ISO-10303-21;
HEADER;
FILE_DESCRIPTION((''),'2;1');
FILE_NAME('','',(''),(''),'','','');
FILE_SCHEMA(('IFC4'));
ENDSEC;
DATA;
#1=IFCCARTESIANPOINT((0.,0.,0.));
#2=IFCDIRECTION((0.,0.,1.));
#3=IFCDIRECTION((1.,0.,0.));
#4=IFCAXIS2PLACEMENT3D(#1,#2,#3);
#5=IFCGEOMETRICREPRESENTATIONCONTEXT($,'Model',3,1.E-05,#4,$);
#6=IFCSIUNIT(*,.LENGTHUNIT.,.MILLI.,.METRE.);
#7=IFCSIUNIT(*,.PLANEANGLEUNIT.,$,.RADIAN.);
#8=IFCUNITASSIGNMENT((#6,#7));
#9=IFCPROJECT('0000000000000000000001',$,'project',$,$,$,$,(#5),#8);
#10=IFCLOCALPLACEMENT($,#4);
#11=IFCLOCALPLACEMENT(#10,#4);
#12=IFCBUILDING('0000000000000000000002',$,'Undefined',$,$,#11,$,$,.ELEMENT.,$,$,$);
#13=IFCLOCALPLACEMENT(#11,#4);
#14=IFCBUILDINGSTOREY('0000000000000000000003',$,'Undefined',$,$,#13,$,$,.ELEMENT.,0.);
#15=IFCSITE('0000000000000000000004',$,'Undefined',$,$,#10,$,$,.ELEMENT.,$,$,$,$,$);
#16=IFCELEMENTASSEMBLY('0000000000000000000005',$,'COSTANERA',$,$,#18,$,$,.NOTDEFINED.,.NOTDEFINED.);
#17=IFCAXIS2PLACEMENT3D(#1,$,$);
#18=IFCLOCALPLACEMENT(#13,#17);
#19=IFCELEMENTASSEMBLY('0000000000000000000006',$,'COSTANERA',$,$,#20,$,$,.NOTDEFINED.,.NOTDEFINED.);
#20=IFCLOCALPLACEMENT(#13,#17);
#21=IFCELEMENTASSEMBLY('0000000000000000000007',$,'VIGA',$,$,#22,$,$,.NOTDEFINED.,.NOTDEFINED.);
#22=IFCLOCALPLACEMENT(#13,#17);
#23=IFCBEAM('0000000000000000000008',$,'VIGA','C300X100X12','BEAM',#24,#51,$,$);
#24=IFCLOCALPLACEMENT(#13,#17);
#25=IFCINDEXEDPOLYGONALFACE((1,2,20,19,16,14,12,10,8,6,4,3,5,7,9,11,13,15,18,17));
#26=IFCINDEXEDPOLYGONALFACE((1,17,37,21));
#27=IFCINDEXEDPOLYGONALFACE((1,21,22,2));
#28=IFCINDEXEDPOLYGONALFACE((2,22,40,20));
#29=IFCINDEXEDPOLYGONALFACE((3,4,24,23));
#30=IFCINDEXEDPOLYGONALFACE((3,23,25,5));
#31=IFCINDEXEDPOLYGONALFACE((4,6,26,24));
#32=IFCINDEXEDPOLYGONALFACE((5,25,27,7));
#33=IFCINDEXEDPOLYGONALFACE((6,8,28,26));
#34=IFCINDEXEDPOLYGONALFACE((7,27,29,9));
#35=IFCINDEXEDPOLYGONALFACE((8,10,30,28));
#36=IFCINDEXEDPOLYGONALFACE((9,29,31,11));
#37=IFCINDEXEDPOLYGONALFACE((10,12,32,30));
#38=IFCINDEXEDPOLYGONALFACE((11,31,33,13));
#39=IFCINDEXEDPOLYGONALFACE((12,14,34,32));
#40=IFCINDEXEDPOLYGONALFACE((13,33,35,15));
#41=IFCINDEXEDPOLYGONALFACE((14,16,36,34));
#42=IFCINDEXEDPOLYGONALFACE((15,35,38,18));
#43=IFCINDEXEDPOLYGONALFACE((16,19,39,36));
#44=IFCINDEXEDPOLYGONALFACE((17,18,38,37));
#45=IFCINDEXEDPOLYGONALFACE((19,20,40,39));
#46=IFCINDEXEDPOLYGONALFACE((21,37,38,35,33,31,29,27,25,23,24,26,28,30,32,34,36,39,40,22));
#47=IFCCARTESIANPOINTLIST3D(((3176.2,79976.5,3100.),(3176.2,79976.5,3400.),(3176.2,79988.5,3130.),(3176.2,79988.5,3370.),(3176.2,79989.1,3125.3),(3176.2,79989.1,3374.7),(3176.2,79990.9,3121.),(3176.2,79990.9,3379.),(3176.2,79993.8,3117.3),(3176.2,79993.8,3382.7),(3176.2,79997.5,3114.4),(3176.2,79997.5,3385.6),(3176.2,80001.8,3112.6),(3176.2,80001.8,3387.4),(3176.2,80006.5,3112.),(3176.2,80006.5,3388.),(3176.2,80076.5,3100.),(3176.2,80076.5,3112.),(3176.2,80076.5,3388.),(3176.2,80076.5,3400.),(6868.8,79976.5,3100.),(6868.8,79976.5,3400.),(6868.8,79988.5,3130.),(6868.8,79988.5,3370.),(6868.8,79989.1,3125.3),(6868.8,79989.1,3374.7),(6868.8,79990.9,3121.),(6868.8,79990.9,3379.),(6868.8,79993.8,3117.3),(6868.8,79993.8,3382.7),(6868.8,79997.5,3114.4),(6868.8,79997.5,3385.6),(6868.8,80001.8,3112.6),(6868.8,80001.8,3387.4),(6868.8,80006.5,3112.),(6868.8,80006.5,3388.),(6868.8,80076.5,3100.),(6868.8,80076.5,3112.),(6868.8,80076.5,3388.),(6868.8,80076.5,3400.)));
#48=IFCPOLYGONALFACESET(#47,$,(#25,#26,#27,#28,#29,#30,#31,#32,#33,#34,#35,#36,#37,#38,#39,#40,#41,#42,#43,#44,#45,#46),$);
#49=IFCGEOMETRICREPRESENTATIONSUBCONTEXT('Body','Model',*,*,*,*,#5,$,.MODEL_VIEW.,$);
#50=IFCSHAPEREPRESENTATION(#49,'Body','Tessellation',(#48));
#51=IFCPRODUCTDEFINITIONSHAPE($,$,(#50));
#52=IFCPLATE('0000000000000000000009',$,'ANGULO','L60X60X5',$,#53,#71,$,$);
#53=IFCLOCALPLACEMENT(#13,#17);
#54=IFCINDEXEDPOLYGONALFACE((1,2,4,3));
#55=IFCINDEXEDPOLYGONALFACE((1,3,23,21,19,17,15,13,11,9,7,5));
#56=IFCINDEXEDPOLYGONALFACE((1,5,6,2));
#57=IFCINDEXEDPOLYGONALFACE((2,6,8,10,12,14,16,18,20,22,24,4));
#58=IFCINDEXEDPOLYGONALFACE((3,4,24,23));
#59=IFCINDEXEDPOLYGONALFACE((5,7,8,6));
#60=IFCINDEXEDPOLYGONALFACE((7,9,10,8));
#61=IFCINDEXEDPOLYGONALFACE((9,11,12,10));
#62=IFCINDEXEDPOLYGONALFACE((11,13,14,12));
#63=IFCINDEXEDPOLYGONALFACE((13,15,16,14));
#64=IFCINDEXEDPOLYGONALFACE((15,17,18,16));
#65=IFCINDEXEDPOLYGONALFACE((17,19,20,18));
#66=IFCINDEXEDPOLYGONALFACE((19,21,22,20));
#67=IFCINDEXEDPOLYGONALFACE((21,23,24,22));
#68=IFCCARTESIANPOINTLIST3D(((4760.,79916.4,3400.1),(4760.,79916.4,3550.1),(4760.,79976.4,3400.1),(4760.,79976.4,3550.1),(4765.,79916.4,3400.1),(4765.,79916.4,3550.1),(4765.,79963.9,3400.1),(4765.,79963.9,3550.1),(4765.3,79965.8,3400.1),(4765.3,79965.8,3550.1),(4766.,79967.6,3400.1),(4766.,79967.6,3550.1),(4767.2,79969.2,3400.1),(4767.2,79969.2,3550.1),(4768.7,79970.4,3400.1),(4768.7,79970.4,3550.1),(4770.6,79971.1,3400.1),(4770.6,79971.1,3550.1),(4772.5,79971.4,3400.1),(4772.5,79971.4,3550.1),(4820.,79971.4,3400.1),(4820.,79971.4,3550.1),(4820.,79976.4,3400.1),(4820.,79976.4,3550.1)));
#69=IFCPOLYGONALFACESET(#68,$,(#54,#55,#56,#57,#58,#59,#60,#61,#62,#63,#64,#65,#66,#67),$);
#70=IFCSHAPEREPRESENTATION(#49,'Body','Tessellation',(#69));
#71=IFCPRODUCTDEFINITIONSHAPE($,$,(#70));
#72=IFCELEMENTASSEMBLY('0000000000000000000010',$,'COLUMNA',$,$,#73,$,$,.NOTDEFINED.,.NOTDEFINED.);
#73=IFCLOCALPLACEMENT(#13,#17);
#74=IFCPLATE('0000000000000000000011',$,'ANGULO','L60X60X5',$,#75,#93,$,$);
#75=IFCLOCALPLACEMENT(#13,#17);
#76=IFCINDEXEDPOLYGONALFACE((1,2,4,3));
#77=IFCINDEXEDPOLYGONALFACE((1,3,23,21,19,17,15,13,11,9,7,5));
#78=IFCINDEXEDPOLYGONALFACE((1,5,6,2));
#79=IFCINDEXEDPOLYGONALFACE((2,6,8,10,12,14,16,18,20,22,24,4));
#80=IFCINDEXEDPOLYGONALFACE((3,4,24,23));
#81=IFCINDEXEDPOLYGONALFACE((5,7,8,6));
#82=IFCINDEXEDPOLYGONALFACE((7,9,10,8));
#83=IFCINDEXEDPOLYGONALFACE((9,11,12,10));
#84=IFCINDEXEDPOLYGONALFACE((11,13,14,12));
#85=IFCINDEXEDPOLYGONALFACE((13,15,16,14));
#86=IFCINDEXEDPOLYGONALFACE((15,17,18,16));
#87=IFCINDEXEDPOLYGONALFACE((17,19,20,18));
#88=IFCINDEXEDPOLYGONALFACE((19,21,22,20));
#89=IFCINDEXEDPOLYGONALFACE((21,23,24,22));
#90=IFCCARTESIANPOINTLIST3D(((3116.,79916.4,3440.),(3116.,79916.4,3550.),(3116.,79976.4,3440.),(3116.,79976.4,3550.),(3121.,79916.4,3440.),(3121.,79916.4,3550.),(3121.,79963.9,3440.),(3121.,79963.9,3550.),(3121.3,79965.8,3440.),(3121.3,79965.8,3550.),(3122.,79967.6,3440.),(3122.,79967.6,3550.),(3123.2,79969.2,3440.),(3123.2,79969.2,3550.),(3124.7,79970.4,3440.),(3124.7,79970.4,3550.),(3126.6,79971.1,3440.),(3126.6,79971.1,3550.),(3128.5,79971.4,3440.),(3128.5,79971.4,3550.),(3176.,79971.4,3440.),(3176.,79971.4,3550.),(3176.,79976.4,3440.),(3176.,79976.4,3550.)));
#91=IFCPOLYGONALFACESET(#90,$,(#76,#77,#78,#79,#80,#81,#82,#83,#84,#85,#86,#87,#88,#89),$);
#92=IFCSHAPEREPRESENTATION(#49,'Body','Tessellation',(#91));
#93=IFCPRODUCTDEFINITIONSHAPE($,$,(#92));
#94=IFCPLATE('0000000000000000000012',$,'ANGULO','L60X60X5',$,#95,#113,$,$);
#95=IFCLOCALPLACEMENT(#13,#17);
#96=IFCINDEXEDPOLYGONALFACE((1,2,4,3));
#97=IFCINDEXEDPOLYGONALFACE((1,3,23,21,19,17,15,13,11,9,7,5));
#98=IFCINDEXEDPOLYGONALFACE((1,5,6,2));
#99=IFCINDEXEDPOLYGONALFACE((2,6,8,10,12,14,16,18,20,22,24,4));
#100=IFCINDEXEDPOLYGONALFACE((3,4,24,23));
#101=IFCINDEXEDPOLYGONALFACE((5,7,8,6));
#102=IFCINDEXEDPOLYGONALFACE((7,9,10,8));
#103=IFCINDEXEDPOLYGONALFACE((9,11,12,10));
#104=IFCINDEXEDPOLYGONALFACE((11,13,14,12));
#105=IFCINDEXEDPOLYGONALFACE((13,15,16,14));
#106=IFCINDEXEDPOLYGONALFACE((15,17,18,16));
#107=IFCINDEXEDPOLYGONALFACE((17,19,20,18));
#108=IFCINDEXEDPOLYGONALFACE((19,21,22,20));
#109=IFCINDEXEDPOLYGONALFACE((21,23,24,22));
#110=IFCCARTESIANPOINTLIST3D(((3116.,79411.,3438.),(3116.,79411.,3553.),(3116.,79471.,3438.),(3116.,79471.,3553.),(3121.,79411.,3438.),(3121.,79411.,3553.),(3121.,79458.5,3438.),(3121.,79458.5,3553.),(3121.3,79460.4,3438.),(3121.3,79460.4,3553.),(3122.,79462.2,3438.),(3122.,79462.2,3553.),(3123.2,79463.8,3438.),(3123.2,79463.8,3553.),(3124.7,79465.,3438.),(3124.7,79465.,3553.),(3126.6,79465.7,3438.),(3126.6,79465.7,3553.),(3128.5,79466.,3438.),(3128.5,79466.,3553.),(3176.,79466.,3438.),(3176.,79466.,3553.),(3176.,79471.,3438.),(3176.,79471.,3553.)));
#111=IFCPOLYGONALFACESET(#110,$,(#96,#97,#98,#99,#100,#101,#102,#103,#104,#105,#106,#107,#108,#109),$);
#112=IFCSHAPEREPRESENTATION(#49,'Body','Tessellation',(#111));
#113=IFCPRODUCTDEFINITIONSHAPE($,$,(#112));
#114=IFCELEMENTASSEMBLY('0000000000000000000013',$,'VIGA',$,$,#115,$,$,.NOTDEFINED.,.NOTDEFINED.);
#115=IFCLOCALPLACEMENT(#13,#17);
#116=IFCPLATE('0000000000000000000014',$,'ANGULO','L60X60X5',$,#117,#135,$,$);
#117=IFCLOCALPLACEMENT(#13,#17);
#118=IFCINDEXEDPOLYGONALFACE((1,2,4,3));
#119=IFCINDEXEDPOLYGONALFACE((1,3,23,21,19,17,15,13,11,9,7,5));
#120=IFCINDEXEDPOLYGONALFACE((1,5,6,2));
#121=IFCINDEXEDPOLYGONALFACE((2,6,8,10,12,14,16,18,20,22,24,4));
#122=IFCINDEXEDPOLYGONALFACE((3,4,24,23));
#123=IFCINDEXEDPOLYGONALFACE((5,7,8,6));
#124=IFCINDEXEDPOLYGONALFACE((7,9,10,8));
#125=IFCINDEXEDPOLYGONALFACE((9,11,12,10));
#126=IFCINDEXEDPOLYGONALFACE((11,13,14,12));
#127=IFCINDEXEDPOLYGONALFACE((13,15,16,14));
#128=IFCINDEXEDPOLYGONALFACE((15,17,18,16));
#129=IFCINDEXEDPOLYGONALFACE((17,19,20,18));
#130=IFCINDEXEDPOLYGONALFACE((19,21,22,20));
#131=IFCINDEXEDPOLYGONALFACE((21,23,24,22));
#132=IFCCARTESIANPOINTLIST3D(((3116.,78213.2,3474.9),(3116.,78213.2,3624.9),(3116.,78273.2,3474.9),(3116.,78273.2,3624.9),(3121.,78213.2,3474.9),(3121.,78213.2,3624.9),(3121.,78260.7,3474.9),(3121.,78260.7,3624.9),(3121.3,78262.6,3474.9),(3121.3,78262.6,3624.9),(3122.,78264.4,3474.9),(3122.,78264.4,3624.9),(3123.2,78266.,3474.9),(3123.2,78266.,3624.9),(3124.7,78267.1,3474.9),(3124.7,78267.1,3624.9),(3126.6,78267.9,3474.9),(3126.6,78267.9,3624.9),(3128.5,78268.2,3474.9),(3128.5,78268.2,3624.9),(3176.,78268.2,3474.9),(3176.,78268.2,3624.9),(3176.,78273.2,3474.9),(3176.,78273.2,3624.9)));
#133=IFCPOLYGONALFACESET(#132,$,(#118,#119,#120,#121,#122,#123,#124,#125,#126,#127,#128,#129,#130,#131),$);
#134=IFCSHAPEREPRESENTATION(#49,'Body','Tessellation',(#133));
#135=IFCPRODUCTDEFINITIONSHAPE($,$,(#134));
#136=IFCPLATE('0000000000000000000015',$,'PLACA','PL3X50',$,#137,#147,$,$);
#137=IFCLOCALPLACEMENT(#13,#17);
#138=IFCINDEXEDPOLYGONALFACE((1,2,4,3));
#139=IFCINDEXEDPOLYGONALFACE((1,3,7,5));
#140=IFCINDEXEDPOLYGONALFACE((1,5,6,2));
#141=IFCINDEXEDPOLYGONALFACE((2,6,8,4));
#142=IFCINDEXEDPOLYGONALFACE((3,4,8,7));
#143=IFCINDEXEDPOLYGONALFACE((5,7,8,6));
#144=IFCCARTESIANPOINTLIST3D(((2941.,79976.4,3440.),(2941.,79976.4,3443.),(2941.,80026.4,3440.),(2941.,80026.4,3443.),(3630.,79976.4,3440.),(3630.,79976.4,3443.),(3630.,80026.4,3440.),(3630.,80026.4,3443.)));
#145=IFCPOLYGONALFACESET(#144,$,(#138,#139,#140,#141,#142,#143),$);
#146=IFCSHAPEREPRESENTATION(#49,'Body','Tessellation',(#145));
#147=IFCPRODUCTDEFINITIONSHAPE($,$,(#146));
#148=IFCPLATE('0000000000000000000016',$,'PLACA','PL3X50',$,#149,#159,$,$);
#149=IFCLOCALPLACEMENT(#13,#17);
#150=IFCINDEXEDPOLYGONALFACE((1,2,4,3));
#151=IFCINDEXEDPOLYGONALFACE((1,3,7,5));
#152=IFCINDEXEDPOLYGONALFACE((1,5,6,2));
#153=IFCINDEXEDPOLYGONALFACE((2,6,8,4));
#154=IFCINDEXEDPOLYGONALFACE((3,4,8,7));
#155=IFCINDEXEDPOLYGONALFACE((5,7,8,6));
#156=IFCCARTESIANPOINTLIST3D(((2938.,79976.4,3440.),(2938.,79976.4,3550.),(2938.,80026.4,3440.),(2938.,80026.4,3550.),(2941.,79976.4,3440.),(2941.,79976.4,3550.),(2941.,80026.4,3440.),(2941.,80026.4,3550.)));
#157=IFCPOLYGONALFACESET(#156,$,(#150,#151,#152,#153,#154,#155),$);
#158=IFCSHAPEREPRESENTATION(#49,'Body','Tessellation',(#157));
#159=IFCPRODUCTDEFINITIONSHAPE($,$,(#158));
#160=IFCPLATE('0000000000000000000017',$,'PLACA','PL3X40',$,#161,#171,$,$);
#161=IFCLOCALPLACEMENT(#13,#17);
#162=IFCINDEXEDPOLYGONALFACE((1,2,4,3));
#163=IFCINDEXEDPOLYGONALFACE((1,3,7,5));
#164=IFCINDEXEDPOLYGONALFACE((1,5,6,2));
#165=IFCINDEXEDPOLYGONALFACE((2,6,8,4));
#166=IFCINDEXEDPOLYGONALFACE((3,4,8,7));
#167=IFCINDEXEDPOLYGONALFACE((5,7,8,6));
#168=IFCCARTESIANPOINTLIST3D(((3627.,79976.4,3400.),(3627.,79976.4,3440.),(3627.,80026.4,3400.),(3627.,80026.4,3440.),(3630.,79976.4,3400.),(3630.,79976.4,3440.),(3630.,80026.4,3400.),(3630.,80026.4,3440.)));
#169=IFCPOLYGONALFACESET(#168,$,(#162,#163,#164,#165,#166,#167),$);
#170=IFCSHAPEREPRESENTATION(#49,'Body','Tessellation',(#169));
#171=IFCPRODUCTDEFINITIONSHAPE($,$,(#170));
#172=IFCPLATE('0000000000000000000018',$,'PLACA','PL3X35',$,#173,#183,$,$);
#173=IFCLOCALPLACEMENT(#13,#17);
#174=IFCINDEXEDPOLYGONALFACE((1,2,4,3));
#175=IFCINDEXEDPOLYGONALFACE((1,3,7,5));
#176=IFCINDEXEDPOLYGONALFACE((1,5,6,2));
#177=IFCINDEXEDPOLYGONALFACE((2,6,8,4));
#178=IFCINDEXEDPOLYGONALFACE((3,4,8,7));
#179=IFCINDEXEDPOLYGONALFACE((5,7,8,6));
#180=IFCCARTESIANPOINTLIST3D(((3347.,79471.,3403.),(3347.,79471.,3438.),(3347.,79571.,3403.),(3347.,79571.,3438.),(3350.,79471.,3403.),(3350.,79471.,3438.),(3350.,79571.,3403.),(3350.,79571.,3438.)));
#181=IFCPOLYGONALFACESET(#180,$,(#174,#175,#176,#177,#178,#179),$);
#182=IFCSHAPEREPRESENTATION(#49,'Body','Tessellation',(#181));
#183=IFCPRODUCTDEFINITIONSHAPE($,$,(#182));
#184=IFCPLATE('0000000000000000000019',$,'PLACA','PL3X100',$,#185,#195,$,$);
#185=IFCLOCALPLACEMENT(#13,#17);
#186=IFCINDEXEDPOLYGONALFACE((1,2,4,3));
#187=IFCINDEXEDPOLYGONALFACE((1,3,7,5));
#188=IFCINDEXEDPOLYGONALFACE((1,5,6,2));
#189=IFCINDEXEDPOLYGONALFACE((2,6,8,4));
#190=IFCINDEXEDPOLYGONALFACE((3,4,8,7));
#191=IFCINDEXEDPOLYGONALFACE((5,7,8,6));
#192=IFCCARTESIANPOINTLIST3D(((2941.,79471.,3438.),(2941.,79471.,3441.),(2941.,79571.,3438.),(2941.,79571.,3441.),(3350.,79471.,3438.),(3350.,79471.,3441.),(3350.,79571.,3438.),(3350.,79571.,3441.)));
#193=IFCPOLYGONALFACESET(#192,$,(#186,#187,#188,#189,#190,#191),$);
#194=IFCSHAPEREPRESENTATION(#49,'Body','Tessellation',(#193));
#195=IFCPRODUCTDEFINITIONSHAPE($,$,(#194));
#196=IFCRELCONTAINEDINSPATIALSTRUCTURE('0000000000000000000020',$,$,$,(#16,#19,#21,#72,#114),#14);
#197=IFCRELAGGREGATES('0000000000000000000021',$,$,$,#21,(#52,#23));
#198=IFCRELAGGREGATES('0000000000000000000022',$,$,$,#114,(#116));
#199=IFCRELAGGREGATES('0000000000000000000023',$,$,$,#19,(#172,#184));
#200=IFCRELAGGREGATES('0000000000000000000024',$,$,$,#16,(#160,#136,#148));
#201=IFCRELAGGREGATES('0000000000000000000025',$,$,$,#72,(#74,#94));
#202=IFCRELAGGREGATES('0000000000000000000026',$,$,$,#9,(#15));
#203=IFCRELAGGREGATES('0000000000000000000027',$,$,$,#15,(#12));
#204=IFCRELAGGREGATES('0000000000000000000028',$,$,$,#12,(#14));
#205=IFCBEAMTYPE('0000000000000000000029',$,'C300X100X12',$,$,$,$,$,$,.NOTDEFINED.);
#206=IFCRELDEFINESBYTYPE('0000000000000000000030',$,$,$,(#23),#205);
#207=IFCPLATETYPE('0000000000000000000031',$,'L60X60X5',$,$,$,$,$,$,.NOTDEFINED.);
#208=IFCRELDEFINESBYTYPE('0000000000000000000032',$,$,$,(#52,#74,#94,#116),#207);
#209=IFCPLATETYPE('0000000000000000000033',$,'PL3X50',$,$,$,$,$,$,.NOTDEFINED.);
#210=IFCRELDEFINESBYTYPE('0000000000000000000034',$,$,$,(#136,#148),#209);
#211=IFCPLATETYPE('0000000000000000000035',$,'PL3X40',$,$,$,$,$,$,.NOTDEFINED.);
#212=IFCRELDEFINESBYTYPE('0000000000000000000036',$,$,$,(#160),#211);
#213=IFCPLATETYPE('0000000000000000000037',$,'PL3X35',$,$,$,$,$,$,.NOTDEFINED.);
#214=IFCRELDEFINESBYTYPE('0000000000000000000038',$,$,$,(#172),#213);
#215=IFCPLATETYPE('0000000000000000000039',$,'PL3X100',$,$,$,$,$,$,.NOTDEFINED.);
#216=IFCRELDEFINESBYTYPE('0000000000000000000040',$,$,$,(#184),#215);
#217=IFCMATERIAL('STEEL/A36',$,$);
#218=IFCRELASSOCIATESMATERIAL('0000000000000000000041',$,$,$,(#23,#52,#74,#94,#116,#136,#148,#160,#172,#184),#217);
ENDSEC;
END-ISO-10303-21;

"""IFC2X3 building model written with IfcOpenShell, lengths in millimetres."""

from ifc_helpers import new_model, si_unit, frame, origin_with_axes, origin_2d_with_axis, place, context, subcontext, project, spatial, polyline, l_section, u_section, outline, extrude, material, type_object, element, aggregate, save


model = new_model("IFC2X3")

# Units and contexts
model_context = context("Model", 3, precision=1e-05, world=origin_with_axes())
body_context = subcontext(model_context, "Body", "Model", "MODEL_VIEW")
ifc_project = project(units=[si_unit("LENGTHUNIT", "METRE", prefix="MILLI"), si_unit("PLANEANGLEUNIT", "RADIAN")], contexts=[model_context])

# Site, building, storey
site_placement = place(None, origin_with_axes())
site = spatial("IfcSite", under=ifc_project, at=site_placement, Name="Undefined", CompositionType="ELEMENT")
building_placement = place(site_placement, origin_with_axes())
building = spatial("IfcBuilding", under=site, at=building_placement, Name="Undefined", CompositionType="ELEMENT")
storey_placement = place(building_placement, origin_with_axes())
storey = spatial("IfcBuildingStorey", under=building, at=storey_placement, Name="Undefined", CompositionType="ELEMENT", Elevation=0.0)

# Element assemblies
assembly_1_placement = place(storey_placement, origin_with_axes())
assembly_1 = element("IfcElementAssembly", 1, at=assembly_1_placement, inside=storey, Name="COSTANERA", AssemblyPlace="NOTDEFINED", PredefinedType="NOTDEFINED")
ifc_material_1 = material(Name="STEEL/A36")
assembly_2_placement = place(storey_placement, origin_with_axes())
assembly_2 = element("IfcElementAssembly", 2, at=assembly_2_placement, inside=storey, Name="COSTANERA", AssemblyPlace="NOTDEFINED", PredefinedType="NOTDEFINED")

# Element assembly, beam, plate
assembly_3_placement = place(storey_placement, origin_with_axes())
assembly_3 = element("IfcElementAssembly", 3, at=assembly_3_placement, inside=storey, Name="VIGA", AssemblyPlace="NOTDEFINED", PredefinedType="NOTDEFINED")
beam_type_1 = type_object("IfcBeamType", Name="C300X100X12", PredefinedType="NOTDEFINED")
beam_1_placement = place(assembly_3_placement, frame((3176.2, 80026.5, 3250.0), z_axis=(0.0, 0.0, -1.0), x_axis=(1.0, 0.0, 0.0)))
beam_1 = element("IfcBeam", 4, at=beam_1_placement, type_object=beam_type_1, material=ifc_material_1, Name="VIGA", Description="C300X100X12", ObjectType="BEAM", context=body_context, shape_type="SweptSolid", body=[
    extrude(u_section(Depth=300.0, FlangeWidth=100.0, WebThickness=12.0, FlangeThickness=12.0, FilletRadius=18.0, at=origin_2d_with_axis()), frame((3692.6, 0.0, 0.0), z_axis=(-1.0, 0.0, 0.0), x_axis=(0.0, -1.0, 0.0)), (0.0, 0.0, 1.0), 3692.6),
])
plate_type_1 = type_object("IfcPlateType", Name="L60X60X5", PredefinedType="NOTDEFINED")
plate_1_placement = place(assembly_3_placement, frame((4790.0, 79946.4, 3400.1), z_axis=(0.0, -1.0, 0.0), x_axis=(0.0, 0.0, 1.0)))
plate_1 = element("IfcPlate", 5, at=plate_1_placement, type_object=plate_type_1, material=ifc_material_1, Name="ANGULO", Description="L60X60X5", context=body_context, shape_type="SweptSolid", body=[
    extrude(l_section(Depth=60.0, Width=60.0, Thickness=5.0, FilletRadius=7.5, at=origin_2d_with_axis()), frame((150.0, 0.0, 0.0), z_axis=(-1.0, 0.0, 0.0), x_axis=(0.0, -1.0, 0.0)), (0.0, 0.0, 1.0), 150.0),
])
aggregate(assembly_3, [plate_1, beam_1])

# Element assembly, plates
assembly_4_placement = place(storey_placement, origin_with_axes())
assembly_4 = element("IfcElementAssembly", 6, at=assembly_4_placement, inside=storey, Name="COLUMNA", AssemblyPlace="NOTDEFINED", PredefinedType="NOTDEFINED")
plate_2_placement = place(assembly_4_placement, frame((3146.0, 79946.4, 3440.0), z_axis=(0.0, -1.0, 0.0), x_axis=(0.0, 0.0, 1.0)))
plate_2 = element("IfcPlate", 7, at=plate_2_placement, type_object=plate_type_1, material=ifc_material_1, Name="ANGULO", Description="L60X60X5", context=body_context, shape_type="SweptSolid", body=[
    extrude(l_section(Depth=60.0, Width=60.0, Thickness=5.0, FilletRadius=7.5, at=origin_2d_with_axis()), frame((110.0, 0.0, 0.0), z_axis=(-1.0, 0.0, 0.0), x_axis=(0.0, -1.0, 0.0)), (0.0, 0.0, 1.0), 110.0),
])
plate_3_placement = place(assembly_4_placement, frame((3146.0, 79441.0, 3438.0), z_axis=(0.0, -1.0, 0.0), x_axis=(0.0, 0.0, 1.0)))
plate_3 = element("IfcPlate", 8, at=plate_3_placement, type_object=plate_type_1, material=ifc_material_1, Name="ANGULO", Description="L60X60X5", context=body_context, shape_type="SweptSolid", body=[
    extrude(l_section(Depth=60.0, Width=60.0, Thickness=5.0, FilletRadius=7.5, at=origin_2d_with_axis()), frame((115.0, 0.0, 0.0), z_axis=(-1.0, 0.0, 0.0), x_axis=(0.0, -1.0, 0.0)), (0.0, 0.0, 1.0), 115.0),
])

# Element assembly, plate
assembly_5_placement = place(storey_placement, origin_with_axes())
assembly_5 = element("IfcElementAssembly", 9, at=assembly_5_placement, inside=storey, Name="VIGA", AssemblyPlace="NOTDEFINED", PredefinedType="NOTDEFINED")
plate_4_placement = place(assembly_5_placement, frame((3146.0, 78243.2, 3474.9), z_axis=(0.0, -1.0, 0.0), x_axis=(0.0, 0.0, 1.0)))
plate_4 = element("IfcPlate", 10, at=plate_4_placement, type_object=plate_type_1, material=ifc_material_1, Name="ANGULO", Description="L60X60X5", context=body_context, shape_type="SweptSolid", body=[
    extrude(l_section(Depth=60.0, Width=60.0, Thickness=5.0, FilletRadius=7.5, at=origin_2d_with_axis()), frame((150.0, 0.0, 0.0), z_axis=(-1.0, 0.0, 0.0), x_axis=(0.0, -1.0, 0.0)), (0.0, 0.0, 1.0), 150.0),
])
aggregate(assembly_5, [plate_4])

# Plates
plate_type_2 = type_object("IfcPlateType", Name="PL3X50", PredefinedType="NOTDEFINED")
plate_5_placement = place(assembly_1_placement, frame((2941.0, 79976.4, 3441.5), z_axis=(0.0, 0.0, 1.0), x_axis=(1.0, 0.0, 0.0)))
plate_5 = element("IfcPlate", 11, at=plate_5_placement, type_object=plate_type_2, material=ifc_material_1, Name="PLACA", Description="PL3X50", context=body_context, shape_type="SweptSolid", body=[
    extrude(outline(polyline([(0.0, 0.0), (689.0, 0.0), (689.0, 50.0), (0.0, 50.0), (0.0, 0.0)])), frame((0.0, 0.0, -1.5), z_axis=(0.0, 0.0, 1.0), x_axis=(1.0, 0.0, 0.0)), (0.0, 0.0, 1.0), 3.0),
])
plate_6_placement = place(assembly_1_placement, frame((2939.5, 79976.4, 3440.0), z_axis=(1.0, 0.0, 0.0), x_axis=(0.0, 1.0, 0.0)))
plate_6 = element("IfcPlate", 12, at=plate_6_placement, type_object=plate_type_2, material=ifc_material_1, Name="PLACA", Description="PL3X50", context=body_context, shape_type="SweptSolid", body=[
    extrude(outline(polyline([(0.0, 0.0), (50.0, 0.0), (50.0, 110.0), (0.0, 110.0), (0.0, 0.0)])), frame((0.0, 0.0, -1.5), z_axis=(0.0, 0.0, 1.0), x_axis=(1.0, 0.0, 0.0)), (0.0, 0.0, 1.0), 3.0),
])
plate_type_3 = type_object("IfcPlateType", Name="PL3X40", PredefinedType="NOTDEFINED")
plate_7_placement = place(assembly_1_placement, frame((3628.5, 79976.4, 3440.0), z_axis=(1.0, 0.0, 0.0), x_axis=(0.0, 0.0, -1.0)))
plate_7 = element("IfcPlate", 13, at=plate_7_placement, type_object=plate_type_3, material=ifc_material_1, Name="PLACA", Description="PL3X40", context=body_context, shape_type="SweptSolid", body=[
    extrude(outline(polyline([(0.0, 0.0), (40.0, 0.0), (40.0, 50.0), (0.0, 50.0), (0.0, 0.0)])), frame((0.0, 0.0, -1.5), z_axis=(0.0, 0.0, 1.0), x_axis=(1.0, 0.0, 0.0)), (0.0, 0.0, 1.0), 3.0),
])
plate_type_4 = type_object("IfcPlateType", Name="PL3X35", PredefinedType="NOTDEFINED")
plate_8_placement = place(assembly_2_placement, frame((3348.5, 79471.0, 3438.0), z_axis=(1.0, 0.0, 0.0), x_axis=(0.0, 0.0, -1.0)))
plate_8 = element("IfcPlate", 14, at=plate_8_placement, type_object=plate_type_4, material=ifc_material_1, Name="PLACA", Description="PL3X35", context=body_context, shape_type="SweptSolid", body=[
    extrude(outline(polyline([(0.0, 0.0), (35.0, 0.0), (35.0, 100.0), (0.0, 100.0), (0.0, 0.0)])), frame((0.0, 0.0, -1.5), z_axis=(0.0, 0.0, 1.0), x_axis=(1.0, 0.0, 0.0)), (0.0, 0.0, 1.0), 3.0),
])
plate_type_5 = type_object("IfcPlateType", Name="PL3X100", PredefinedType="NOTDEFINED")
plate_9_placement = place(assembly_2_placement, frame((2941.0, 79471.0, 3439.5), z_axis=(0.0, 0.0, 1.0), x_axis=(1.0, 0.0, 0.0)))
plate_9 = element("IfcPlate", 15, at=plate_9_placement, type_object=plate_type_5, material=ifc_material_1, Name="PLACA", Description="PL3X100", context=body_context, shape_type="SweptSolid", body=[
    extrude(outline(polyline([(0.0, 0.0), (409.0, 0.0), (409.0, 100.0), (0.0, 100.0), (0.0, 0.0)])), frame((0.0, 0.0, -1.5), z_axis=(0.0, 0.0, 1.0), x_axis=(1.0, 0.0, 0.0)), (0.0, 0.0, 1.0), 3.0),
])

aggregate(assembly_2, [plate_8, plate_9])

aggregate(assembly_1, [plate_7, plate_5, plate_6])

aggregate(assembly_4, [plate_2, plate_3])

save(model, "model.ifc")
